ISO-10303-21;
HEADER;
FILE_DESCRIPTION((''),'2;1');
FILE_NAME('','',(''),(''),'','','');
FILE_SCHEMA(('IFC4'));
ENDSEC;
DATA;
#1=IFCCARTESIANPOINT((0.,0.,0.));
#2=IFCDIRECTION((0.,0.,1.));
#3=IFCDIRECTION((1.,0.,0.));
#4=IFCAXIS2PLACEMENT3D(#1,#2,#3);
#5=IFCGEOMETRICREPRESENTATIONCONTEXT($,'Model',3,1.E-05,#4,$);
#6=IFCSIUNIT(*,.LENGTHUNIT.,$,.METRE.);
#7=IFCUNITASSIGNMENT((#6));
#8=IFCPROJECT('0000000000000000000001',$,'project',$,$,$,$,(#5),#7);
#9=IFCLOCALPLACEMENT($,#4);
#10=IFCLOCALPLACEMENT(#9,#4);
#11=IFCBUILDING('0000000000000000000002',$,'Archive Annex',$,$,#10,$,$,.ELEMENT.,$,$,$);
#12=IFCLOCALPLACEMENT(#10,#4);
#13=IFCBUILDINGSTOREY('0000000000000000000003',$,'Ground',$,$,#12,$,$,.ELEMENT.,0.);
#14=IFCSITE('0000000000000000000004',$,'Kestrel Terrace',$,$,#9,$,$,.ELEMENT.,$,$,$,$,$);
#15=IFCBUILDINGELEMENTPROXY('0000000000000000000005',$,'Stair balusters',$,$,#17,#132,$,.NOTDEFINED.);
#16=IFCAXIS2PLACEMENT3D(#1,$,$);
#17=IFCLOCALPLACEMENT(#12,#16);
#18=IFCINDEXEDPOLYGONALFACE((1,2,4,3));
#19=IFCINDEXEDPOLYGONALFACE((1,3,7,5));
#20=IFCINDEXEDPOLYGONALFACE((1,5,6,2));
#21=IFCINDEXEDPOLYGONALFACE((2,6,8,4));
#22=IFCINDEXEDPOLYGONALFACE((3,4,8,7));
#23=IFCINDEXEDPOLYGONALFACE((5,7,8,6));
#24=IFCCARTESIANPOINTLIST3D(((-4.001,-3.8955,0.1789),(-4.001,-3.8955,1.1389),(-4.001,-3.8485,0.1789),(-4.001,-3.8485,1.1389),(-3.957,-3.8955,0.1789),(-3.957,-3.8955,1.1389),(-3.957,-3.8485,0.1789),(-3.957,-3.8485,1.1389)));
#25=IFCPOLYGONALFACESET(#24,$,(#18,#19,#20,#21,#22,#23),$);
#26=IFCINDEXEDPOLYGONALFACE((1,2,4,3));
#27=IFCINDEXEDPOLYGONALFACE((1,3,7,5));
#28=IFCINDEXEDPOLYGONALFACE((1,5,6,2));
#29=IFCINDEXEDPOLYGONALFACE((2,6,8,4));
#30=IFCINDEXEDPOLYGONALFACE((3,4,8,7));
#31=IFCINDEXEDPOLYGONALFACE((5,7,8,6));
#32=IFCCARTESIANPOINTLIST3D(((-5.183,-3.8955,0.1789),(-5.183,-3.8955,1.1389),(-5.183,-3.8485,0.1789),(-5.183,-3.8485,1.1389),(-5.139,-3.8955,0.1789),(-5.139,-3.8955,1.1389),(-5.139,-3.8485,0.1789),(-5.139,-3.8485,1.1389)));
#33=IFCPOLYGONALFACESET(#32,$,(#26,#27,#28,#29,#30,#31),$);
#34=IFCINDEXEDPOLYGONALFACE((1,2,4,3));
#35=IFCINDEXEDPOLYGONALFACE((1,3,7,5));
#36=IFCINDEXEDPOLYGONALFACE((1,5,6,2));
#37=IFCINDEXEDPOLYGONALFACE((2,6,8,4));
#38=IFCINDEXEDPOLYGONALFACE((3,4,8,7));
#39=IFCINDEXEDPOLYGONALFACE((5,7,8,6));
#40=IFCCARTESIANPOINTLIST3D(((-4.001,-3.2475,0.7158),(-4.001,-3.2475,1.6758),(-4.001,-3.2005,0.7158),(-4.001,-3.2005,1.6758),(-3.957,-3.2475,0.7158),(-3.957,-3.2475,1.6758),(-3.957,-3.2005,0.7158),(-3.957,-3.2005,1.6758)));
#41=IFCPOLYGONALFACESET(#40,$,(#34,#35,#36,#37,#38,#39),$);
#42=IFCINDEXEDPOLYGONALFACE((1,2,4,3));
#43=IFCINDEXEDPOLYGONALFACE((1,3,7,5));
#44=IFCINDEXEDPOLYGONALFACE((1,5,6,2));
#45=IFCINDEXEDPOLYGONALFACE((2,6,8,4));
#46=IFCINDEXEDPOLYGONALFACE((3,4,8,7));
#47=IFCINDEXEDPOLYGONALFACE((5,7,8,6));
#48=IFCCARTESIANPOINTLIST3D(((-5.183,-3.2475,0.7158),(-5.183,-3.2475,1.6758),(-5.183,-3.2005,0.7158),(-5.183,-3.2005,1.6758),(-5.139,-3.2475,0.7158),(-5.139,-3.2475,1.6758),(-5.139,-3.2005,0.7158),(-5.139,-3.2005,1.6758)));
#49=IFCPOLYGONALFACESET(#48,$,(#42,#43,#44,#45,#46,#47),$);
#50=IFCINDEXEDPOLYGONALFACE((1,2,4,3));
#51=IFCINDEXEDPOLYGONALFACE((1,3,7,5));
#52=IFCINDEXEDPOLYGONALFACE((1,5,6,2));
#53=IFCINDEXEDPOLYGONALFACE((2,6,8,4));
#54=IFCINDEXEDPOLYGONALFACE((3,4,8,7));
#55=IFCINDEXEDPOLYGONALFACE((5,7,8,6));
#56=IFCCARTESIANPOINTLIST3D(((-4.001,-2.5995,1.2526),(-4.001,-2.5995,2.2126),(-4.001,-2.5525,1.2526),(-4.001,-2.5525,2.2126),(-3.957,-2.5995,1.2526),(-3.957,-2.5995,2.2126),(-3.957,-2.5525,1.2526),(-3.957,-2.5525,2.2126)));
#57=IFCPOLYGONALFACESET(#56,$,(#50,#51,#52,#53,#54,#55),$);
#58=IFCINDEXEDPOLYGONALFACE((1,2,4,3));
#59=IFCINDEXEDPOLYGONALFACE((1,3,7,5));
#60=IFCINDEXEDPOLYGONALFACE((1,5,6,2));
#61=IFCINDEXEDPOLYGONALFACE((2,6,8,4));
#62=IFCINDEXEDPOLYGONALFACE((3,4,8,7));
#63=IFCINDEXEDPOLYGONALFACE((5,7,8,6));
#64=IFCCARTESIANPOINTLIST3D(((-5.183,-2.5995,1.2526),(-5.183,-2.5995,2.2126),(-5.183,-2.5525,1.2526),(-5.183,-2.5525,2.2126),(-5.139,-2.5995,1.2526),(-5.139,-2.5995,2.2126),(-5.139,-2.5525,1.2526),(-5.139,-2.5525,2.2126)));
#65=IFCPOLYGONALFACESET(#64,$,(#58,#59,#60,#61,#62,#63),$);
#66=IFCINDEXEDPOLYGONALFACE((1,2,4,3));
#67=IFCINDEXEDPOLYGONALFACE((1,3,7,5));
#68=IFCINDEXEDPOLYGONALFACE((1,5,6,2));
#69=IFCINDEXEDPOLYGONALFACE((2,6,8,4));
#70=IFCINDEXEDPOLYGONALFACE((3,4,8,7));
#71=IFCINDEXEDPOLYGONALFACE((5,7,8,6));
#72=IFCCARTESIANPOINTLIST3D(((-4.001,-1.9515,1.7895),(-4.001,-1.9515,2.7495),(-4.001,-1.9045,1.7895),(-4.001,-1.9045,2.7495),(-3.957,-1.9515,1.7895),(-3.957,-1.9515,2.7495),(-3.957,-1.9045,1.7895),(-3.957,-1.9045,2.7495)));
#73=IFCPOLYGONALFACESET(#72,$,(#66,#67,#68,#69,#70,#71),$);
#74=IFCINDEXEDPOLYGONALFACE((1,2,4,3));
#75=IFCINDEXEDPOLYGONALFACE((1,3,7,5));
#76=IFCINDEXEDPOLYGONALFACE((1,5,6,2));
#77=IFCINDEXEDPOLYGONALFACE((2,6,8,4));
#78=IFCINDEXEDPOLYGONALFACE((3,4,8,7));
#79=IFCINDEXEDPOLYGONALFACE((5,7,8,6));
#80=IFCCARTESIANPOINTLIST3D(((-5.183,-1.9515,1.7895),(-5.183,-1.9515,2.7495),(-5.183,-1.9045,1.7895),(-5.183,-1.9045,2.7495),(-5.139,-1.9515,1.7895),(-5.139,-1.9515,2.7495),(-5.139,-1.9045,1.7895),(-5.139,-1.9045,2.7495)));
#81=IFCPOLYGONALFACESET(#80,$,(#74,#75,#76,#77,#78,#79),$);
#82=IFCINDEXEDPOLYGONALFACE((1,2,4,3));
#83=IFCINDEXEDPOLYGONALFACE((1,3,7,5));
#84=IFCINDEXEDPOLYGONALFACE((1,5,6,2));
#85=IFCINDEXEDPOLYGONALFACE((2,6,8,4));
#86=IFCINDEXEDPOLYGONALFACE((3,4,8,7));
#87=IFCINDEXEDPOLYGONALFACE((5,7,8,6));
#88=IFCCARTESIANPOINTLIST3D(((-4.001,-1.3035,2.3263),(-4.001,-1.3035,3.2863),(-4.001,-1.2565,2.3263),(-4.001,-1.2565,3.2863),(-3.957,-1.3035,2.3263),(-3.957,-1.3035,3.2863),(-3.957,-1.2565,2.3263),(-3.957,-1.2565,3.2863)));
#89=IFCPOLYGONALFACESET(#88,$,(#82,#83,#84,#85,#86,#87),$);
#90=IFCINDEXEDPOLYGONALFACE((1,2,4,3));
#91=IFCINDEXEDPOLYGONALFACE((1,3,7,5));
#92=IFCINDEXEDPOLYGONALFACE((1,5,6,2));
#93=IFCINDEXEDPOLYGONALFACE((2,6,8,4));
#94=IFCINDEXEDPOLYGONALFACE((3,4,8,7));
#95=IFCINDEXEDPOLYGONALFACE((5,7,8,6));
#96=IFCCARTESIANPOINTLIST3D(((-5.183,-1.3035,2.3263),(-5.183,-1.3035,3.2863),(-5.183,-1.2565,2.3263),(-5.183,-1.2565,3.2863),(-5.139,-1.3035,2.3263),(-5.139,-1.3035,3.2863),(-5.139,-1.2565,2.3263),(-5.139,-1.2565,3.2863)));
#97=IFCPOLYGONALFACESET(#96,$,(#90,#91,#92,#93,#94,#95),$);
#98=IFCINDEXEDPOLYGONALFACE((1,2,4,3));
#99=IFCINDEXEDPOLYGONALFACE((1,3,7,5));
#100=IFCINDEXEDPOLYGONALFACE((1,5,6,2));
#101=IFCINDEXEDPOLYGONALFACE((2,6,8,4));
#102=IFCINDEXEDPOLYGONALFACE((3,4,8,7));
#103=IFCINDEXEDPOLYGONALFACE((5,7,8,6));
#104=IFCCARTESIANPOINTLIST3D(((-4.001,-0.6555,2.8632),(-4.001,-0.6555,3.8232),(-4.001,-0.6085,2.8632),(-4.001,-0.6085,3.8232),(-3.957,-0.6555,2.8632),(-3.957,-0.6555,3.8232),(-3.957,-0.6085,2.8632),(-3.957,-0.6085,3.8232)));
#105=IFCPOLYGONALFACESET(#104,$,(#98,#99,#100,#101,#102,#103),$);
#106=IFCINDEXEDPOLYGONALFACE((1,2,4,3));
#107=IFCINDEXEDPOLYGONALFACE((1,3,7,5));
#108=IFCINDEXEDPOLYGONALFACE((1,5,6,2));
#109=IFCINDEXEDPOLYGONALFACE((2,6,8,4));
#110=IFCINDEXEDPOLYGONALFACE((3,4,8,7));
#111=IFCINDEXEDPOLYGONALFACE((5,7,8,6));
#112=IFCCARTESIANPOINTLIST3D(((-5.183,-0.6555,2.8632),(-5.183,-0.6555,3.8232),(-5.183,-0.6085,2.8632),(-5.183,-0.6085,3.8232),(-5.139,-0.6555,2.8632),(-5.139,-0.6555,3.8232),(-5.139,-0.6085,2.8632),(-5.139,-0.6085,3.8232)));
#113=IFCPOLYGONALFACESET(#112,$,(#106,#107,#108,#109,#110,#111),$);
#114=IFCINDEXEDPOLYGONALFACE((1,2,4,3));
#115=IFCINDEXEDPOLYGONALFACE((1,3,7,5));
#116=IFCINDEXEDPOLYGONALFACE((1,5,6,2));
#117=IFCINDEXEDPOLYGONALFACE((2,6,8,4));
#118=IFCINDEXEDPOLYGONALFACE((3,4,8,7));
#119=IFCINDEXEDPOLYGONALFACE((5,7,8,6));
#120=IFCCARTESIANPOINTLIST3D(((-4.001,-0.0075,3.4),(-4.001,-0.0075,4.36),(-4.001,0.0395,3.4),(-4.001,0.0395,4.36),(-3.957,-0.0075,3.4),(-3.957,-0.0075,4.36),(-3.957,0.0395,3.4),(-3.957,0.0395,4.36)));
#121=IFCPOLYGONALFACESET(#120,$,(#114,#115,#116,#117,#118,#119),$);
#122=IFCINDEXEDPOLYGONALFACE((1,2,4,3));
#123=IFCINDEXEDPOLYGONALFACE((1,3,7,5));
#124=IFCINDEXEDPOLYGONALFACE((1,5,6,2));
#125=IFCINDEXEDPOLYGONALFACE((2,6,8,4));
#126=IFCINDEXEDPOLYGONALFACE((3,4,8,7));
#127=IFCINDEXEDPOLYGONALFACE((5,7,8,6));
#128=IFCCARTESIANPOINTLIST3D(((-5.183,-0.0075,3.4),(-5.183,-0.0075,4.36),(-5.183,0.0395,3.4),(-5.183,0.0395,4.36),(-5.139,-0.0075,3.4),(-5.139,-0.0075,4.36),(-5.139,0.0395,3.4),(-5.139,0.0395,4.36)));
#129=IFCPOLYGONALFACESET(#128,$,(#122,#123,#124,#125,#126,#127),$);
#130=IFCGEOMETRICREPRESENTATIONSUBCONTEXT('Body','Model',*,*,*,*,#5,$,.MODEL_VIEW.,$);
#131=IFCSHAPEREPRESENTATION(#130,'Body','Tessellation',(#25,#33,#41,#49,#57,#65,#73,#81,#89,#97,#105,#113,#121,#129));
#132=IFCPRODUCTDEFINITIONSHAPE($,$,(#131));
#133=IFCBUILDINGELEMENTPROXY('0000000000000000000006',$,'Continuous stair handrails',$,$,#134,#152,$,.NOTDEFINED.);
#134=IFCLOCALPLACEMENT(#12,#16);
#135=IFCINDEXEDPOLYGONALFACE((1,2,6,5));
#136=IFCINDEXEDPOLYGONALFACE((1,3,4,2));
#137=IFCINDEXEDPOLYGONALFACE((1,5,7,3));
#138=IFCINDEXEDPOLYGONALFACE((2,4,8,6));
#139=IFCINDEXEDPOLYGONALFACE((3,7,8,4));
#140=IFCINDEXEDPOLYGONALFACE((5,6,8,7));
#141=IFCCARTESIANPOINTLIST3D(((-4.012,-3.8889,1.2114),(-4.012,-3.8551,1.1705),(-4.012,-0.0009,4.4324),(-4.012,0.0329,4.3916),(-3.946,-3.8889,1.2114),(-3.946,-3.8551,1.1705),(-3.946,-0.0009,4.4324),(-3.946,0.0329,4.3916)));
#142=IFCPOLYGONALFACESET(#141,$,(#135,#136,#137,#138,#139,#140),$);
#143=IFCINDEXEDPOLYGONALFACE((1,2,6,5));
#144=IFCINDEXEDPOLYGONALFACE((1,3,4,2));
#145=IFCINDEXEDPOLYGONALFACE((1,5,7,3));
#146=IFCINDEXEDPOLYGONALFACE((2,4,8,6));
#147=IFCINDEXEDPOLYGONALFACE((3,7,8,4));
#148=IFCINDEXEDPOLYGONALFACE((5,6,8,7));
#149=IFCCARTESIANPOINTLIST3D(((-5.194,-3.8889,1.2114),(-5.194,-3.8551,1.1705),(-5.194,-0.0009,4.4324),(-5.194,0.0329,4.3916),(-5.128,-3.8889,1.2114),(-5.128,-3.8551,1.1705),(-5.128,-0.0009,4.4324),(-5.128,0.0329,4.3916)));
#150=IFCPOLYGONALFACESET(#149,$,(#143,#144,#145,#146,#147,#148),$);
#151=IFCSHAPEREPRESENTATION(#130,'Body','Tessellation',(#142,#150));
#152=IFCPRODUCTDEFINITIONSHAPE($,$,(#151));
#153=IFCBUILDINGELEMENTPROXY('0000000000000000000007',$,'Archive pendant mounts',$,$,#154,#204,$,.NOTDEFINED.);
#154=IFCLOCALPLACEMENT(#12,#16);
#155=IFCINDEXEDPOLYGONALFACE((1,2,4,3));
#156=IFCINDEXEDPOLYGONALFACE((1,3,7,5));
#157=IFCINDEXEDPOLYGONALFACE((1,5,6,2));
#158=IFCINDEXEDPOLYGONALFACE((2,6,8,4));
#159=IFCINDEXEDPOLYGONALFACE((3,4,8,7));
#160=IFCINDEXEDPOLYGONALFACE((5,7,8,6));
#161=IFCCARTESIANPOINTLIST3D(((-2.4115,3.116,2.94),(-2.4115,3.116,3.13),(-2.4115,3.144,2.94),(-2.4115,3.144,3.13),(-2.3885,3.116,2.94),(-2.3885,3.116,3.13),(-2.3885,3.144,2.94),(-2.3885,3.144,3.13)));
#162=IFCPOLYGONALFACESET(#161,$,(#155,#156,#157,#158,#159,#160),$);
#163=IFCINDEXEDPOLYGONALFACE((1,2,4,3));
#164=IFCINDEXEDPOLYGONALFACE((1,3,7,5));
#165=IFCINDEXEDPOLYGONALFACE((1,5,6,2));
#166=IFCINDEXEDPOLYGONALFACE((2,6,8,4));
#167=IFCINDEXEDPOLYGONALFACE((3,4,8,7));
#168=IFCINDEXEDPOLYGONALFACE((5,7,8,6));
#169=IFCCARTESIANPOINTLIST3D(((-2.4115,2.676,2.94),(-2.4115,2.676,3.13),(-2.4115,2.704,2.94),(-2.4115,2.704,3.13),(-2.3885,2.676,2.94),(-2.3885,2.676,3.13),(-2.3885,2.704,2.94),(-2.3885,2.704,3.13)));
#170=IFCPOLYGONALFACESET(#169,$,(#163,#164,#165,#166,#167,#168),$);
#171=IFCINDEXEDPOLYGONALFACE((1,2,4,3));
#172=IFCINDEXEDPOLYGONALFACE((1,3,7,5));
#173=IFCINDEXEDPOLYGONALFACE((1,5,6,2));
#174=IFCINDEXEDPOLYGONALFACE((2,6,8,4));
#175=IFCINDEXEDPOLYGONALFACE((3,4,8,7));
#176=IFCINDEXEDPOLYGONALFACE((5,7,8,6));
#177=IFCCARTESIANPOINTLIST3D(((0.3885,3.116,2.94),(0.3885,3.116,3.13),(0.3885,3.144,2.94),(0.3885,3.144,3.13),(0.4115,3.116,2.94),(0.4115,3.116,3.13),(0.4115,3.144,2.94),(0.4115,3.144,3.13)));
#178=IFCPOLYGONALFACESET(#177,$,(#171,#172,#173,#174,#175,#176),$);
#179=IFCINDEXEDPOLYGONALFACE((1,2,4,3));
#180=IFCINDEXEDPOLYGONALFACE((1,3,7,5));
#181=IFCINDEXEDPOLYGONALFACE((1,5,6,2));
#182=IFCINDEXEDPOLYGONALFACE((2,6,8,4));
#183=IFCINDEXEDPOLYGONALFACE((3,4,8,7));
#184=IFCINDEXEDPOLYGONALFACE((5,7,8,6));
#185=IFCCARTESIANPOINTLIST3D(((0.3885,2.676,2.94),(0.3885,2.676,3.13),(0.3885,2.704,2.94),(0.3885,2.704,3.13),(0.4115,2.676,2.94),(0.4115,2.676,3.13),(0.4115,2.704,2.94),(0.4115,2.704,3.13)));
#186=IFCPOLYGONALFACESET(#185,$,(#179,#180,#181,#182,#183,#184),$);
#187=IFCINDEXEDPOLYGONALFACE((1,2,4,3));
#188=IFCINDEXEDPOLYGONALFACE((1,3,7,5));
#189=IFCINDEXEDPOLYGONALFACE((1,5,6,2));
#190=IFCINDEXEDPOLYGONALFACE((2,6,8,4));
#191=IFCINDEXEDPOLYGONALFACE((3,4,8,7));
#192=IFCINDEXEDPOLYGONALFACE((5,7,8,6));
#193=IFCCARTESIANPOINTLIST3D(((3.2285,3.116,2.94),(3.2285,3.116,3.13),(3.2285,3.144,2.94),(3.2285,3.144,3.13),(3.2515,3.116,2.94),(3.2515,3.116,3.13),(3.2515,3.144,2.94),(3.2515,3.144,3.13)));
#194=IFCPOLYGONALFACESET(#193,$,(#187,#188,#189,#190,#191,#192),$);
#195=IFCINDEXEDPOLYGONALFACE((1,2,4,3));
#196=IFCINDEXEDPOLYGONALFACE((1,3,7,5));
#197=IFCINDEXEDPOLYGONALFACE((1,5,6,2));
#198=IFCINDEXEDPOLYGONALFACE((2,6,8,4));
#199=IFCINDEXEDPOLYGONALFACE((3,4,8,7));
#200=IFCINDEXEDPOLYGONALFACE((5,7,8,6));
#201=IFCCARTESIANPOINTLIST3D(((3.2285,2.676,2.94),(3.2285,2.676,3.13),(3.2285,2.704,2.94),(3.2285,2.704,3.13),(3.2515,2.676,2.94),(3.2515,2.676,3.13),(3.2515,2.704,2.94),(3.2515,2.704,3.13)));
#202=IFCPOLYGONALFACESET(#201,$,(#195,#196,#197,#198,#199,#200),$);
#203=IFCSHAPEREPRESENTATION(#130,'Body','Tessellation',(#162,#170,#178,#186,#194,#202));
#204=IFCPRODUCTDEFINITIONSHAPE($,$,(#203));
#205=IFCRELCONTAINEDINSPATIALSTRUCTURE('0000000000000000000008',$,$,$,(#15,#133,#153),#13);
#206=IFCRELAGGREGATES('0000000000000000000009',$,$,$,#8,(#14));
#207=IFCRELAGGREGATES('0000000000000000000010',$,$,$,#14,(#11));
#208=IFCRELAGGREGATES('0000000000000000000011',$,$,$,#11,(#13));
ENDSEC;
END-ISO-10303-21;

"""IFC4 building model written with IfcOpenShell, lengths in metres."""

from ifc_helpers import new_model, si_unit, frame, origin_with_axes, origin_2d, place, context, subcontext, project, spatial, rectangle, extrude, element, save


model = new_model("IFC4")

# Units and contexts
model_context = context("Model", 3, precision=1e-05, world=origin_with_axes())
body_context = subcontext(model_context, "Body", "Model", "MODEL_VIEW")
ifc_project = project(units=[si_unit("LENGTHUNIT", "METRE")], contexts=[model_context])

# Site, building, storey
site_placement = place(None, origin_with_axes())
site = spatial("IfcSite", under=ifc_project, at=site_placement, Name="Kestrel Terrace", CompositionType="ELEMENT")
building_placement = place(site_placement, origin_with_axes())
building = spatial("IfcBuilding", under=site, at=building_placement, Name="Archive Annex", CompositionType="ELEMENT")
storey_placement = place(building_placement, origin_with_axes())
storey = spatial("IfcBuildingStorey", under=building, at=storey_placement, Name="Ground", CompositionType="ELEMENT", Elevation=0.0)

# Building element proxies
proxy_1_placement = place(storey_placement, origin_with_axes())
element("IfcBuildingElementProxy", 1, at=proxy_1_placement, inside=storey, Name="Stair balusters", PredefinedType="NOTDEFINED", context=body_context, shape_type="SweptSolid", body=[
    extrude(rectangle(XDim=0.044, YDim=0.047, at=origin_2d()), frame((-3.979, -3.872, 0.1789), z_axis=(0.0, 0.0, 1.0), x_axis=(1.0, 0.0, 0.0)), (0.0, 0.0, 1.0), 0.96),
    extrude(rectangle(XDim=0.044, YDim=0.047, at=origin_2d()), frame((-5.161, -3.872, 0.1789), z_axis=(0.0, 0.0, 1.0), x_axis=(1.0, 0.0, 0.0)), (0.0, 0.0, 1.0), 0.96),
    extrude(rectangle(XDim=0.044, YDim=0.047, at=origin_2d()), frame((-3.979, -3.224, 0.7158), z_axis=(0.0, 0.0, 1.0), x_axis=(1.0, 0.0, 0.0)), (0.0, 0.0, 1.0), 0.96),
    extrude(rectangle(XDim=0.044, YDim=0.047, at=origin_2d()), frame((-5.161, -3.224, 0.7158), z_axis=(0.0, 0.0, 1.0), x_axis=(1.0, 0.0, 0.0)), (0.0, 0.0, 1.0), 0.96),
    extrude(rectangle(XDim=0.044, YDim=0.047, at=origin_2d()), frame((-3.979, -2.576, 1.2526), z_axis=(0.0, 0.0, 1.0), x_axis=(1.0, 0.0, 0.0)), (0.0, 0.0, 1.0), 0.96),
    extrude(rectangle(XDim=0.044, YDim=0.047, at=origin_2d()), frame((-5.161, -2.576, 1.2526), z_axis=(0.0, 0.0, 1.0), x_axis=(1.0, 0.0, 0.0)), (0.0, 0.0, 1.0), 0.96),
    extrude(rectangle(XDim=0.044, YDim=0.047, at=origin_2d()), frame((-3.979, -1.928, 1.7895), z_axis=(0.0, 0.0, 1.0), x_axis=(1.0, 0.0, 0.0)), (0.0, 0.0, 1.0), 0.96),
    extrude(rectangle(XDim=0.044, YDim=0.047, at=origin_2d()), frame((-5.161, -1.928, 1.7895), z_axis=(0.0, 0.0, 1.0), x_axis=(1.0, 0.0, 0.0)), (0.0, 0.0, 1.0), 0.96),
    extrude(rectangle(XDim=0.044, YDim=0.047, at=origin_2d()), frame((-3.979, -1.28, 2.3263), z_axis=(0.0, 0.0, 1.0), x_axis=(1.0, 0.0, 0.0)), (0.0, 0.0, 1.0), 0.96),
    extrude(rectangle(XDim=0.044, YDim=0.047, at=origin_2d()), frame((-5.161, -1.28, 2.3263), z_axis=(0.0, 0.0, 1.0), x_axis=(1.0, 0.0, 0.0)), (0.0, 0.0, 1.0), 0.96),
    extrude(rectangle(XDim=0.044, YDim=0.047, at=origin_2d()), frame((-3.979, -0.632, 2.8632), z_axis=(0.0, 0.0, 1.0), x_axis=(1.0, 0.0, 0.0)), (0.0, 0.0, 1.0), 0.96),
    extrude(rectangle(XDim=0.044, YDim=0.047, at=origin_2d()), frame((-5.161, -0.632, 2.8632), z_axis=(0.0, 0.0, 1.0), x_axis=(1.0, 0.0, 0.0)), (0.0, 0.0, 1.0), 0.96),
    extrude(rectangle(XDim=0.044, YDim=0.047, at=origin_2d()), frame((-3.979, 0.016, 3.4), z_axis=(0.0, 0.0, 1.0), x_axis=(1.0, 0.0, 0.0)), (0.0, 0.0, 1.0), 0.96),
    extrude(rectangle(XDim=0.044, YDim=0.047, at=origin_2d()), frame((-5.161, 0.016, 3.4), z_axis=(0.0, 0.0, 1.0), x_axis=(1.0, 0.0, 0.0)), (0.0, 0.0, 1.0), 0.96),
])
proxy_2_placement = place(storey_placement, origin_with_axes())
element("IfcBuildingElementProxy", 2, at=proxy_2_placement, inside=storey, Name="Continuous stair handrails", PredefinedType="NOTDEFINED", context=body_context, shape_type="SweptSolid", body=[
    extrude(rectangle(XDim=0.066, YDim=0.053, at=origin_2d()), frame((-3.979, -3.872, 1.1909), z_axis=(0.0, 0.770064, 0.637967), x_axis=(1.0, 0.0, 0.0)), (0.0, 0.0, 1.0), 5.0489),
    extrude(rectangle(XDim=0.066, YDim=0.053, at=origin_2d()), frame((-5.161, -3.872, 1.1909), z_axis=(0.0, 0.770064, 0.637967), x_axis=(1.0, 0.0, 0.0)), (0.0, 0.0, 1.0), 5.0489),
])
proxy_3_placement = place(storey_placement, origin_with_axes())
element("IfcBuildingElementProxy", 3, at=proxy_3_placement, inside=storey, Name="Archive pendant mounts", PredefinedType="NOTDEFINED", context=body_context, shape_type="SweptSolid", body=[
    extrude(rectangle(XDim=0.023, YDim=0.028, at=origin_2d()), frame((-2.4, 3.13, 2.94), z_axis=(0.0, 0.0, 1.0), x_axis=(1.0, 0.0, 0.0)), (0.0, 0.0, 1.0), 0.19),
    extrude(rectangle(XDim=0.023, YDim=0.028, at=origin_2d()), frame((-2.4, 2.69, 2.94), z_axis=(0.0, 0.0, 1.0), x_axis=(1.0, 0.0, 0.0)), (0.0, 0.0, 1.0), 0.19),
    extrude(rectangle(XDim=0.023, YDim=0.028, at=origin_2d()), frame((0.4, 3.13, 2.94), z_axis=(0.0, 0.0, 1.0), x_axis=(1.0, 0.0, 0.0)), (0.0, 0.0, 1.0), 0.19),
    extrude(rectangle(XDim=0.023, YDim=0.028, at=origin_2d()), frame((0.4, 2.69, 2.94), z_axis=(0.0, 0.0, 1.0), x_axis=(1.0, 0.0, 0.0)), (0.0, 0.0, 1.0), 0.19),
    extrude(rectangle(XDim=0.023, YDim=0.028, at=origin_2d()), frame((3.24, 3.13, 2.94), z_axis=(0.0, 0.0, 1.0), x_axis=(1.0, 0.0, 0.0)), (0.0, 0.0, 1.0), 0.19),
    extrude(rectangle(XDim=0.023, YDim=0.028, at=origin_2d()), frame((3.24, 2.69, 2.94), z_axis=(0.0, 0.0, 1.0), x_axis=(1.0, 0.0, 0.0)), (0.0, 0.0, 1.0), 0.19),
])

save(model, "model.ifc")
